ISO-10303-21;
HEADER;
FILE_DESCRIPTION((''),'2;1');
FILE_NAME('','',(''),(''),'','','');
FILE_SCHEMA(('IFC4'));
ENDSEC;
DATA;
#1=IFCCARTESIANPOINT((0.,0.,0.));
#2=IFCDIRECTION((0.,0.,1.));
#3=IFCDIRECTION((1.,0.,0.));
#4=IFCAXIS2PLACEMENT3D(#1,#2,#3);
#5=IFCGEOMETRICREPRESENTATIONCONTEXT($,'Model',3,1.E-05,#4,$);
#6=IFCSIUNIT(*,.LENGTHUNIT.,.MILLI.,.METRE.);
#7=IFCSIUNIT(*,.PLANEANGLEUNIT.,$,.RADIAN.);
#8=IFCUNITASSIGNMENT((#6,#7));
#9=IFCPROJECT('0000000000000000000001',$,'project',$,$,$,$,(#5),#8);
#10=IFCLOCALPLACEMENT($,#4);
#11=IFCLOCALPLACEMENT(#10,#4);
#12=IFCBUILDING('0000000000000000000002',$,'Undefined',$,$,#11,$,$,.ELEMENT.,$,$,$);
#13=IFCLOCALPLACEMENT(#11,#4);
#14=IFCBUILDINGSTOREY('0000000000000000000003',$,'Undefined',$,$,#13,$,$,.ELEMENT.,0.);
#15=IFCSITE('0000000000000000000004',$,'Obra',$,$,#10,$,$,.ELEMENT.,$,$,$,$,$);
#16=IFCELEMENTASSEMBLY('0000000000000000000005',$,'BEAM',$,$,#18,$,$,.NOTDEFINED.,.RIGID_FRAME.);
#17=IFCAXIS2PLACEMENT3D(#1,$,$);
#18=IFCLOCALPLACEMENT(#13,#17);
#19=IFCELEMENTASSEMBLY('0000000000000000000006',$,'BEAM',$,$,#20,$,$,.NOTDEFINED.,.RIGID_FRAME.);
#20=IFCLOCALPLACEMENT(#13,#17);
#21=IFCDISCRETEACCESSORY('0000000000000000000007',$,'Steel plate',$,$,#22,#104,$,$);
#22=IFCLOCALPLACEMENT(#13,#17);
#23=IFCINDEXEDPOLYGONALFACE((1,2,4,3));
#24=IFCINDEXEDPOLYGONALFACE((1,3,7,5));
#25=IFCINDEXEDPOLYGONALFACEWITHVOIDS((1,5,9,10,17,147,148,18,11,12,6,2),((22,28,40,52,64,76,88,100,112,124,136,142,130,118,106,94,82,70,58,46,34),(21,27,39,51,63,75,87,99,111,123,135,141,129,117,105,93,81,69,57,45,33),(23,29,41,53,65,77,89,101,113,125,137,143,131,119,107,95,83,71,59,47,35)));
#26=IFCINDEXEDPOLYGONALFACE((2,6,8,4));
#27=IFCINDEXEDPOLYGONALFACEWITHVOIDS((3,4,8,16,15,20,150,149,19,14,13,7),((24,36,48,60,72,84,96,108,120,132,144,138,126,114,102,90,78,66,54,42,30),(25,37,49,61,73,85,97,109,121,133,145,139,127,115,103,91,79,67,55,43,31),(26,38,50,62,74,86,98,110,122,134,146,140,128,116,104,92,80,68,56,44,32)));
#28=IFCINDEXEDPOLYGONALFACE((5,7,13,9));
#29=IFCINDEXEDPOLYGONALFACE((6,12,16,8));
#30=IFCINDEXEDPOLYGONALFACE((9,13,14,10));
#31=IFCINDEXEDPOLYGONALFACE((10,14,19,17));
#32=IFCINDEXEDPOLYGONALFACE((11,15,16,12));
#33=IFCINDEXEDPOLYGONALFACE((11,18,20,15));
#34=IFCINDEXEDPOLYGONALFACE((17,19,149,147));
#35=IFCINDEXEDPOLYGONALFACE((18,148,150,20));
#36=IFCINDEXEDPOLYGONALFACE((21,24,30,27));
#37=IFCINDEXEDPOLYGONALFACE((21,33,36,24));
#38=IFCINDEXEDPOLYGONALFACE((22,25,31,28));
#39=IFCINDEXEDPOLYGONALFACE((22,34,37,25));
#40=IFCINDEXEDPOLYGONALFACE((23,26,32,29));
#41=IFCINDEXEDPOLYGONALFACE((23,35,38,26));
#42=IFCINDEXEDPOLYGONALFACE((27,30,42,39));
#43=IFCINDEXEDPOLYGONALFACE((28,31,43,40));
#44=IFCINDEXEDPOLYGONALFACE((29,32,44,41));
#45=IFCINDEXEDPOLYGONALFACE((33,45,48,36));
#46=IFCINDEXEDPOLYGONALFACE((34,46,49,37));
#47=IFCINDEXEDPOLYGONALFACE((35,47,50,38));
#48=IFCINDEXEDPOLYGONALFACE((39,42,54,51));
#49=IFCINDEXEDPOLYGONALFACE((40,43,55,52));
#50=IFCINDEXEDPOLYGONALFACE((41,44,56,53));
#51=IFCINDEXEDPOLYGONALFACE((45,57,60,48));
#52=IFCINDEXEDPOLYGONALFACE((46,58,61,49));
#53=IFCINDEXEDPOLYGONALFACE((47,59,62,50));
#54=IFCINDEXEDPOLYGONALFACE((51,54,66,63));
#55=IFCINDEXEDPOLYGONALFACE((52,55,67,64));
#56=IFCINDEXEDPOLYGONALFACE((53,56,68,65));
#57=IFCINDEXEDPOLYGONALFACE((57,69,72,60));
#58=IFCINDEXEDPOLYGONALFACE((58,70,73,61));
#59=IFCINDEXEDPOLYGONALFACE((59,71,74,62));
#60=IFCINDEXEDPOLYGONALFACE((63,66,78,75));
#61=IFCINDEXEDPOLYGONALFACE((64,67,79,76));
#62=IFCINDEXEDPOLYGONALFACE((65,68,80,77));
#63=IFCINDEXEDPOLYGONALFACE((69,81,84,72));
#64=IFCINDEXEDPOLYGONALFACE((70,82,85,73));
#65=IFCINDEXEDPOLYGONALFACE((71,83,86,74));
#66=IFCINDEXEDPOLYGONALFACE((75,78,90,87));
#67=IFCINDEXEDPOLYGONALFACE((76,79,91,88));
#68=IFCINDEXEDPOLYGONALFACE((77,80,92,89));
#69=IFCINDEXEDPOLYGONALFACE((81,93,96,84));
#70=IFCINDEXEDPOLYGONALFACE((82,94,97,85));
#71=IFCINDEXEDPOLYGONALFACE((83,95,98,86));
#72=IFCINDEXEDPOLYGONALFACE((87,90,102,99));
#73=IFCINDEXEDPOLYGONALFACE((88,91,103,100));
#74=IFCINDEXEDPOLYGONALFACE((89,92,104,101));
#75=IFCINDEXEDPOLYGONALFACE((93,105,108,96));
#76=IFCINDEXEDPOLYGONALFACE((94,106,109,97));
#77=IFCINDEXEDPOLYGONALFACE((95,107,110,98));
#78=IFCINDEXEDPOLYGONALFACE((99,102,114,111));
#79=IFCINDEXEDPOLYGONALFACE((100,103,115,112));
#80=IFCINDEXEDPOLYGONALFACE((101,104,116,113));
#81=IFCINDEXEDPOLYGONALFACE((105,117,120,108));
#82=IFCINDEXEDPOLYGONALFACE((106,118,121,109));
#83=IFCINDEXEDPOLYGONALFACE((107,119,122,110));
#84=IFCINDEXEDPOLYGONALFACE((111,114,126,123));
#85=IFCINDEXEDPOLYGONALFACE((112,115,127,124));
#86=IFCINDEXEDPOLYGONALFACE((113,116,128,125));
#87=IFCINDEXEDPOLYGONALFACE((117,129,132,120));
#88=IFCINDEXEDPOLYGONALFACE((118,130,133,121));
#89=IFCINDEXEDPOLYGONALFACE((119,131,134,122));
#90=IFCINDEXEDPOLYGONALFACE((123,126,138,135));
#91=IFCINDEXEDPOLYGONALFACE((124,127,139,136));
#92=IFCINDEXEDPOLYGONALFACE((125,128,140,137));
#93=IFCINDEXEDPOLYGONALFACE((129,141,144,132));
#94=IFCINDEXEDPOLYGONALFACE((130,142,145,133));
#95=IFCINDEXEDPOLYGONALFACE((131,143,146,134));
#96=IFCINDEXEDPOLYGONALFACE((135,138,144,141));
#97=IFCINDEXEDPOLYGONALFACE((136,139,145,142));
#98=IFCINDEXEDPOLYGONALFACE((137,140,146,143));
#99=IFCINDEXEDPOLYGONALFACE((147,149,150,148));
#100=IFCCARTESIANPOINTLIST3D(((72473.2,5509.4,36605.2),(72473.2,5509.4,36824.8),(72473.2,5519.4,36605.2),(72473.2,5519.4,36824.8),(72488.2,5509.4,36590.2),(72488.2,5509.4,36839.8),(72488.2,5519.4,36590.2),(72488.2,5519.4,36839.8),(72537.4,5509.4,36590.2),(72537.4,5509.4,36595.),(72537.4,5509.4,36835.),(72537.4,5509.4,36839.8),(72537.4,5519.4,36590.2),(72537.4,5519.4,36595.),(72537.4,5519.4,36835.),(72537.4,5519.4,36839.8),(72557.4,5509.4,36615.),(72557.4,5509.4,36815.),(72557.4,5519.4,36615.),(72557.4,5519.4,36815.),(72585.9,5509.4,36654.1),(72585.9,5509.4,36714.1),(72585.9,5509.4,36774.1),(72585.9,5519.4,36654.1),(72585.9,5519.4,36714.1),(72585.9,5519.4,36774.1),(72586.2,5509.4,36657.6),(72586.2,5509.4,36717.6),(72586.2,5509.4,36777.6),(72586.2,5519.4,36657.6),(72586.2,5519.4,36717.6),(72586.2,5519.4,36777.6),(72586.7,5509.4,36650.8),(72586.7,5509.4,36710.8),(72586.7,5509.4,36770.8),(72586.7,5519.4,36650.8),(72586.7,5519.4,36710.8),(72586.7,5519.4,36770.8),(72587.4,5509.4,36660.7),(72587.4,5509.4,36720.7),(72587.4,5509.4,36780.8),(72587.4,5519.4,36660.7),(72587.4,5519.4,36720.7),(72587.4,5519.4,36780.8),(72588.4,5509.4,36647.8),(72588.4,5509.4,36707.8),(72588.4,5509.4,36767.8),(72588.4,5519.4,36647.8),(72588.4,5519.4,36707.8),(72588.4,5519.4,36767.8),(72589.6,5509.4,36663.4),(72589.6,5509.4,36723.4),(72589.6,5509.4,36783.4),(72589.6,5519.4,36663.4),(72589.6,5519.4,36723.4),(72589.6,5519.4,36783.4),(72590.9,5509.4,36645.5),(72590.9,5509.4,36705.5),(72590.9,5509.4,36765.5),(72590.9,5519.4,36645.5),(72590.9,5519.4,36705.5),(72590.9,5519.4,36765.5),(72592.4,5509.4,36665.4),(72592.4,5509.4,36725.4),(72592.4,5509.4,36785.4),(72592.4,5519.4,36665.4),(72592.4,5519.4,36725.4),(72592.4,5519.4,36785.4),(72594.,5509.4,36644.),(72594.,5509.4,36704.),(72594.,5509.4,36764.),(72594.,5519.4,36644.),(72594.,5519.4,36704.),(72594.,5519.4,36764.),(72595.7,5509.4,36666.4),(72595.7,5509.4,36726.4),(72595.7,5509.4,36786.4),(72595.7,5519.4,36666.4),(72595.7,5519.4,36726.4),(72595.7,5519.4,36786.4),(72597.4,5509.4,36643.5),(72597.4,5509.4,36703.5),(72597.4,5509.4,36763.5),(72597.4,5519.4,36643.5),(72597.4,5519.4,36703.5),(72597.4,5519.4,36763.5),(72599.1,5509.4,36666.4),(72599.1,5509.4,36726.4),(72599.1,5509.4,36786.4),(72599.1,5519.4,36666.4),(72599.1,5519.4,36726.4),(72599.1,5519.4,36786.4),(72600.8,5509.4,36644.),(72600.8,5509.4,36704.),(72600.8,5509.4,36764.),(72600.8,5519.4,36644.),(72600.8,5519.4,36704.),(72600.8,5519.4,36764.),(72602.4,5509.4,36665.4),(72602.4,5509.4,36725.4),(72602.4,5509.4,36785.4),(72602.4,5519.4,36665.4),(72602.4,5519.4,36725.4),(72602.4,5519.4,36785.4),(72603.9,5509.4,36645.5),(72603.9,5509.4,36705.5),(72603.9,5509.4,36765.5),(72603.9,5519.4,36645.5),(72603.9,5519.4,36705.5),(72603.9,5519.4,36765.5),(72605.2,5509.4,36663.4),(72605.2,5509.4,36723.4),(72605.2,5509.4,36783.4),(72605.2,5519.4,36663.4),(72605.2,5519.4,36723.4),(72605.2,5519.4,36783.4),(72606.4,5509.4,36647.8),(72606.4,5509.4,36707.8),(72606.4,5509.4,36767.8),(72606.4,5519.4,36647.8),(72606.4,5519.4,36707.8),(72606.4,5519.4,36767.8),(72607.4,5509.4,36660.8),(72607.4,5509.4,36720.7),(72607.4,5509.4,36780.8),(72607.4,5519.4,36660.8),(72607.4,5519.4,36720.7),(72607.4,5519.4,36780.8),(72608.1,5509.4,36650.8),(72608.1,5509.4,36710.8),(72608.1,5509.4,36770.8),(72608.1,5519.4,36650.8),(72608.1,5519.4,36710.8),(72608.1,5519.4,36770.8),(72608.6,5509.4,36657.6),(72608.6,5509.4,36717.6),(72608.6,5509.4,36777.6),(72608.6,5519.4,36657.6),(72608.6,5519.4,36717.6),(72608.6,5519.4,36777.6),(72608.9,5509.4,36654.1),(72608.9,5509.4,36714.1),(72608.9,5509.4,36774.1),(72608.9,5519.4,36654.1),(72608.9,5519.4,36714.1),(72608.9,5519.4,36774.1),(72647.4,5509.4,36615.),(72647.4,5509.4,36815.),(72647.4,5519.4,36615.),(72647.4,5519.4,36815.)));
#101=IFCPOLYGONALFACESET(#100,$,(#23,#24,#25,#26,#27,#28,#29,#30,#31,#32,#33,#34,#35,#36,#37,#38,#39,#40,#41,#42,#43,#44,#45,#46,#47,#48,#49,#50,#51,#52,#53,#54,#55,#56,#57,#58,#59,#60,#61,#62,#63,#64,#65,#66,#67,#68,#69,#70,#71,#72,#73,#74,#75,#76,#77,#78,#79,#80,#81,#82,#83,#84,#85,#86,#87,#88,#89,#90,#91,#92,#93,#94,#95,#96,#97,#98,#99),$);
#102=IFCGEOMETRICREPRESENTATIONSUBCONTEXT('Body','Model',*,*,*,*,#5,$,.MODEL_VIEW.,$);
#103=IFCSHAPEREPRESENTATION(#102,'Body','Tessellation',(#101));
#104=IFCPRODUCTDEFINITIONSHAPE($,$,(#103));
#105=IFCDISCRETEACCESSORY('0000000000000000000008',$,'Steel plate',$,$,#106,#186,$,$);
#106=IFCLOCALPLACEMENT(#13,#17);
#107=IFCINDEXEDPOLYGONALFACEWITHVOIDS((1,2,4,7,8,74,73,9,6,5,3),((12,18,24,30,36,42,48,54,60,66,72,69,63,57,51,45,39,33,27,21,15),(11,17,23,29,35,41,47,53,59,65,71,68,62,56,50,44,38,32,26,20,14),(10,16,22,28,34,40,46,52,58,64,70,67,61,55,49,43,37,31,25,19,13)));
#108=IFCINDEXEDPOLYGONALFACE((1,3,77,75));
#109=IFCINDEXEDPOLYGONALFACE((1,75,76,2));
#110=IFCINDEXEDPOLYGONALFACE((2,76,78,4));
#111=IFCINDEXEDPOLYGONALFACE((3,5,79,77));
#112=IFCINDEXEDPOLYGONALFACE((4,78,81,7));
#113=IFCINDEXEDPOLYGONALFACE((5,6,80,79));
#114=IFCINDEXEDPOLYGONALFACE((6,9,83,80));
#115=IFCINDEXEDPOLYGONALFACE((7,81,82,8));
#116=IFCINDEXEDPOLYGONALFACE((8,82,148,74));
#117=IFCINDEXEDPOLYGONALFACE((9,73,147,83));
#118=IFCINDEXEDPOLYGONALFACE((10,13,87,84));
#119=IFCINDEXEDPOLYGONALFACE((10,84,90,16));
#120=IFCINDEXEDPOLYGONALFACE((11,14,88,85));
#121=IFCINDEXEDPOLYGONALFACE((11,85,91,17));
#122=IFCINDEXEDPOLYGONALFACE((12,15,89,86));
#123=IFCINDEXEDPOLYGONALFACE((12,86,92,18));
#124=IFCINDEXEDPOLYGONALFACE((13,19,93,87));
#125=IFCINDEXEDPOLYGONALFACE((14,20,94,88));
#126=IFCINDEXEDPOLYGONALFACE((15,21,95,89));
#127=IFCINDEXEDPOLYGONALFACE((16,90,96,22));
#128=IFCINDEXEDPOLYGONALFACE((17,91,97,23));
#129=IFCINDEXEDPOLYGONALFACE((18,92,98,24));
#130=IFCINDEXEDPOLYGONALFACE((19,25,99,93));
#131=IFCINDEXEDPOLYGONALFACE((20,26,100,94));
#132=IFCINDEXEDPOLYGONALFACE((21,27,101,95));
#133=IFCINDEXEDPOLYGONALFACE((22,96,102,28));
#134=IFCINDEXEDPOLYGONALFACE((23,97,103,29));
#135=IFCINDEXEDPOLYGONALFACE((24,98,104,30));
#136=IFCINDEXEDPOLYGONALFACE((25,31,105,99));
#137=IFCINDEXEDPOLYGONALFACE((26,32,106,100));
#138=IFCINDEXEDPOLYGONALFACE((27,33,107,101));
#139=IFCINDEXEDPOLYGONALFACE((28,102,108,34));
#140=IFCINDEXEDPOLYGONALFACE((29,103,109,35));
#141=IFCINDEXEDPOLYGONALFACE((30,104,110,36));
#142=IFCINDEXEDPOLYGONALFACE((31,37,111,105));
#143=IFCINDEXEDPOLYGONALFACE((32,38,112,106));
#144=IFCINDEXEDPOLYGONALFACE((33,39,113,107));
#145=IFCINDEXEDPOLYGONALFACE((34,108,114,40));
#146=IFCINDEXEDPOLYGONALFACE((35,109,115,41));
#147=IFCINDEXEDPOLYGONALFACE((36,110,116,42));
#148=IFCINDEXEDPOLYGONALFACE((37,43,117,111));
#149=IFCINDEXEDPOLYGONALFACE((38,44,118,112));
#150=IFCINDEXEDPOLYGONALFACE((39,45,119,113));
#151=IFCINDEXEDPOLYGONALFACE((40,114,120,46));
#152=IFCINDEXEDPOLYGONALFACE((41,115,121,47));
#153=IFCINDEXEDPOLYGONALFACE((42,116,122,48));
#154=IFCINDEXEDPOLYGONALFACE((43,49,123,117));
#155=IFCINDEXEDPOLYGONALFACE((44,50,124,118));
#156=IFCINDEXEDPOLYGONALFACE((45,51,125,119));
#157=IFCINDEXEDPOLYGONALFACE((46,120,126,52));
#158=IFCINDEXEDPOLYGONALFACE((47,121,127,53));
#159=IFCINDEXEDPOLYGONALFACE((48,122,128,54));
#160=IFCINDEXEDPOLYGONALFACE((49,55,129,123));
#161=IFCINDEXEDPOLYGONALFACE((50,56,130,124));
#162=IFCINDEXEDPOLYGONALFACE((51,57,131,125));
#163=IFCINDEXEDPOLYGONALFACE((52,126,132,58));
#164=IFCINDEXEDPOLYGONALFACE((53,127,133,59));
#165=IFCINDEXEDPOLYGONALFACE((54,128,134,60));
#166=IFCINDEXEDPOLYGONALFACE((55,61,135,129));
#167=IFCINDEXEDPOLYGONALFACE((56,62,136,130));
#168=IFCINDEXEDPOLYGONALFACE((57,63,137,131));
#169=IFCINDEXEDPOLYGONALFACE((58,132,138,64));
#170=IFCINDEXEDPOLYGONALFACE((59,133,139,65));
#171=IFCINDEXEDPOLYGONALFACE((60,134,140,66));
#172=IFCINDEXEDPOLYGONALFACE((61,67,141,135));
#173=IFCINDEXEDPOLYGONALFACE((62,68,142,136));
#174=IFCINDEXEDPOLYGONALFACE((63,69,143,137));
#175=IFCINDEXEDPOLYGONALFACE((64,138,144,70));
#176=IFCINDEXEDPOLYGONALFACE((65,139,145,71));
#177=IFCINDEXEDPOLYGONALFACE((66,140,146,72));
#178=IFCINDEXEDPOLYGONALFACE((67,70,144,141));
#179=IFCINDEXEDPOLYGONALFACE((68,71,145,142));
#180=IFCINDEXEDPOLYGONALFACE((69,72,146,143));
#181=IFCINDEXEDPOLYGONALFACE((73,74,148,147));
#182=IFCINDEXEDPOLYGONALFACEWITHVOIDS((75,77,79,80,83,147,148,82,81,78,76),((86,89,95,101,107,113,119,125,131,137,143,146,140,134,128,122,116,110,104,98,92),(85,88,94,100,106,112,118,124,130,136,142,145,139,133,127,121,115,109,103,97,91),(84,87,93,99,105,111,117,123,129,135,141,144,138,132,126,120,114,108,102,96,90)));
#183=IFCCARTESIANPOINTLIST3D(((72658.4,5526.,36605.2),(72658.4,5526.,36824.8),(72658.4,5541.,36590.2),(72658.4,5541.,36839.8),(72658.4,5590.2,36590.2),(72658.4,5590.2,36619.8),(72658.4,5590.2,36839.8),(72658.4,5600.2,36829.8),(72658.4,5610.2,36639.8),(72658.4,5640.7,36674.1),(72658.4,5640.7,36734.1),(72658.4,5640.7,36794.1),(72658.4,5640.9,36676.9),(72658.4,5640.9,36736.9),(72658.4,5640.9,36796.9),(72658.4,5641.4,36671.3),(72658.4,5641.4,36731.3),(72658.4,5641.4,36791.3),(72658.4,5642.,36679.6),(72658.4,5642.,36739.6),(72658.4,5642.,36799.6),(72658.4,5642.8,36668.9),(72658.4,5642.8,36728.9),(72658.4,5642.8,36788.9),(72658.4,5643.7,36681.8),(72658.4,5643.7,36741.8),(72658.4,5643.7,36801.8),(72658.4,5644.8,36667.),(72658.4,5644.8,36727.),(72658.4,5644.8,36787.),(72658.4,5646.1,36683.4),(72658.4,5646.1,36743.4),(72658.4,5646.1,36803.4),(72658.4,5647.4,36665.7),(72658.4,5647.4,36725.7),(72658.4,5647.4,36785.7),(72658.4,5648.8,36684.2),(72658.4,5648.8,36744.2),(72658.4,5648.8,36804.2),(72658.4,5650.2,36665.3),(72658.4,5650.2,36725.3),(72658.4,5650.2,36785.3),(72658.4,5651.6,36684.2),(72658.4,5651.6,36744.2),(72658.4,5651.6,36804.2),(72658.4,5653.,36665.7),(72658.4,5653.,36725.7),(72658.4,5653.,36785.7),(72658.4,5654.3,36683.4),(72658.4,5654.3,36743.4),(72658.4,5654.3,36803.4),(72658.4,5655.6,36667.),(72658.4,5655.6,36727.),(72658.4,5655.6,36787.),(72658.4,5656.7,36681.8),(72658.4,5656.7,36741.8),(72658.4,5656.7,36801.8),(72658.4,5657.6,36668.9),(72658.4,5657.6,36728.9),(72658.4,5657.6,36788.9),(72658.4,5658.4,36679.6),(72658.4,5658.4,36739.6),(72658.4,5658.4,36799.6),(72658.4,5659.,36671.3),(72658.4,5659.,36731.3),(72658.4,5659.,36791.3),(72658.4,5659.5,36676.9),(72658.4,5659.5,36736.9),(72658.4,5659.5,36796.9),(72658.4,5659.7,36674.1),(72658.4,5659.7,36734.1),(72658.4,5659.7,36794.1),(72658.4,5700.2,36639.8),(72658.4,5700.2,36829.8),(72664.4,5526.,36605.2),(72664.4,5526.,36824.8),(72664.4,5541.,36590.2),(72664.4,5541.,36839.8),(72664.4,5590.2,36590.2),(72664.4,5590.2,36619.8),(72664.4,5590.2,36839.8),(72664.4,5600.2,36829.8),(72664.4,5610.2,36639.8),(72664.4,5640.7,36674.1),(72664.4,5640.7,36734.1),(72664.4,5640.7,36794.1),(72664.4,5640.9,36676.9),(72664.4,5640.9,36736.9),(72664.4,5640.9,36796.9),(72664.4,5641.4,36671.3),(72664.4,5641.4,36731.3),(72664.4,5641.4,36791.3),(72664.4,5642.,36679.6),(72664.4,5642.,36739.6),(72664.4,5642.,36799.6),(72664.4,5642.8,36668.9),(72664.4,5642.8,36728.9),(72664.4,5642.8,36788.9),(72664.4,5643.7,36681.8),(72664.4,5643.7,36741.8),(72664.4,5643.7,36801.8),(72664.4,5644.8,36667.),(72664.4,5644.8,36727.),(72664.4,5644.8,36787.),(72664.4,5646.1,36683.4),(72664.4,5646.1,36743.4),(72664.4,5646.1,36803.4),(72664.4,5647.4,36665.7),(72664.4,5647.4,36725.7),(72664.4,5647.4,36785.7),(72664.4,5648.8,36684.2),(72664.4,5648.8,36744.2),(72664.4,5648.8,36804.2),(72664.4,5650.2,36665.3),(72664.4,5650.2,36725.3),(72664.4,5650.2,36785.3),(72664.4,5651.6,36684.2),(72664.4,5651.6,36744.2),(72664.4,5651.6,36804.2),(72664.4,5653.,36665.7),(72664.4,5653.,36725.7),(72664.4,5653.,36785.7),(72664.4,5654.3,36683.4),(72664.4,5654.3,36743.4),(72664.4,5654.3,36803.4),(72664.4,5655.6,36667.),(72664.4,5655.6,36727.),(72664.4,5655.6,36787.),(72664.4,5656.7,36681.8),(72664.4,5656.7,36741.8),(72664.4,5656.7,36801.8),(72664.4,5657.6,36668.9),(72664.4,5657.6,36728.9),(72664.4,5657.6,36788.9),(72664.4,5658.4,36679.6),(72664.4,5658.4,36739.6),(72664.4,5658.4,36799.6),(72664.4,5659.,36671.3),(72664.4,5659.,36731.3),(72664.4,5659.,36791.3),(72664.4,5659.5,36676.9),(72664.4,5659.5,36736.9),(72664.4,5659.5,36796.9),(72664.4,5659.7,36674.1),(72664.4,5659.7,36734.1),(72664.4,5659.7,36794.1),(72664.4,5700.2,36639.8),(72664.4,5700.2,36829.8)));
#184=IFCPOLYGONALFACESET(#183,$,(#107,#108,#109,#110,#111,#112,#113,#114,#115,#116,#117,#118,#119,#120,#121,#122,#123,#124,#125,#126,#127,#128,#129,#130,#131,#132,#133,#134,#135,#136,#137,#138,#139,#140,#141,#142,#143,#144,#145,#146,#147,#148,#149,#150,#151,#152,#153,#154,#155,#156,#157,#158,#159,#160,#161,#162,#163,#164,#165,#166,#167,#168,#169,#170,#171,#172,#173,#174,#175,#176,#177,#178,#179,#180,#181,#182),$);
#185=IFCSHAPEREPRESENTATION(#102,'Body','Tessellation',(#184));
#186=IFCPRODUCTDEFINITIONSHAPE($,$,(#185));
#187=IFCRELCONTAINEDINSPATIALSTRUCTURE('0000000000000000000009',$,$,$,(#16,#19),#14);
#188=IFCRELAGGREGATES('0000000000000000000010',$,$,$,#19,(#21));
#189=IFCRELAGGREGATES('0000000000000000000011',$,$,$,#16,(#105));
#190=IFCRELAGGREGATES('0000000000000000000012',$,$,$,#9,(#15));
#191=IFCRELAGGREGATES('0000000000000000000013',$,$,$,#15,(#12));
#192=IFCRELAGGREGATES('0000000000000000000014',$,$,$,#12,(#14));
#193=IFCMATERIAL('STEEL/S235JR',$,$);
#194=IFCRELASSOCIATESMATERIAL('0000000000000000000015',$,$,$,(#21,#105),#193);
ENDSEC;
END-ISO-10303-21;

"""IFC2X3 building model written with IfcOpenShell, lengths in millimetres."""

from ifc_helpers import new_model, si_unit, frame, origin_with_axes, origin_2d_with_axis, place, context, subcontext, project, spatial, polyline, circle, outline, extrude, source, transform, mapped, material, element, aggregate, save


model = new_model("IFC2X3")

# Units and contexts
model_context = context("Model", 3, precision=1e-05, world=origin_with_axes())
body_context = subcontext(model_context, "Body", "Model", "MODEL_VIEW")
ifc_project = project(units=[si_unit("LENGTHUNIT", "METRE", prefix="MILLI"), si_unit("PLANEANGLEUNIT", "RADIAN")], contexts=[model_context])

# Site, building, storey
site_placement = place(None, origin_with_axes())
site = spatial("IfcSite", under=ifc_project, at=site_placement, Name="Obra", CompositionType="ELEMENT")
building_placement = place(site_placement, origin_with_axes())
building = spatial("IfcBuilding", under=site, at=building_placement, Name="Undefined", CompositionType="ELEMENT")
storey_placement = place(building_placement, origin_with_axes())
storey = spatial("IfcBuildingStorey", under=building, at=storey_placement, Name="Undefined", CompositionType="ELEMENT", Elevation=0.0)

# Shared definitions
ifc_material_1 = material(Name="STEEL/S235JR")

# Element assembly
assembly_1_placement = place(storey_placement, origin_with_axes())
assembly_1 = element("IfcElementAssembly", 1, at=assembly_1_placement, inside=storey, Name="BEAM", AssemblyPlace="NOTDEFINED", PredefinedType="RIGID_FRAME")

# Element assembly, discrete accessory, opening
assembly_2_placement = place(storey_placement, origin_with_axes())
assembly_2 = element("IfcElementAssembly", 2, at=assembly_2_placement, inside=storey, Name="BEAM", AssemblyPlace="NOTDEFINED", PredefinedType="RIGID_FRAME")
discrete_accessory_1_placement = place(assembly_2_placement, frame((72473.2, 5514.4, 36605.2), z_axis=(0.000002, -1.0, 0.0), x_axis=(0.707107, 0.000001, -0.707107)))
discrete_accessory_1 = element("IfcDiscreteAccessory", 3, at=discrete_accessory_1_placement, material=ifc_material_1, Name="Steel plate", context=body_context, shape_type="SweptSolid", body=[
    extrude(outline(polyline([(0.0, 0.0), (21.2, 0.0), (56.0, 34.8), (52.6, 38.2), (52.6, 66.5), (116.2, 130.1), (-25.2, 271.5), (-88.8, 207.9), (-117.1, 207.9), (-120.5, 211.3), (-155.3, 176.5), (-155.3, 155.3), (0.0, 0.0)])), frame((0.0, 0.0, -5.0), z_axis=(0.0, 0.0, 1.0), x_axis=(1.0, 0.0, 0.0)), (0.0, 0.0, 1.0), 10.0),
])
shared_shape_1 = source(origin_with_axes(), body_context, "Body", "SweptSolid", [
    extrude(circle(Radius=11.5, at=origin_2d_with_axis()), frame((0.0, -13.4, 0.0), z_axis=(0.0, 1.0, 0.0), x_axis=(1.0, 0.0, 0.0)), (0.0, 0.0, 1.0), 10.2),
])
opening_1_placement = place(assembly_2_placement, frame((72547.4, 5522.7, 36815.0), z_axis=(1.0, 0.000002, 0.0), x_axis=(0.0, 0.0, -1.0)))
element("IfcOpeningElement", 4, at=opening_1_placement, cuts=discrete_accessory_1, ObjectType="Opening", context=body_context, shape_type="MappedRepresentation", body=[
    mapped(shared_shape_1, transform((40.0, 0.0, 50.0))),
    mapped(shared_shape_1, transform((100.0, 0.0, 50.0))),
    mapped(shared_shape_1, transform((160.0, 0.0, 50.0))),
])
aggregate(assembly_2, [discrete_accessory_1])

# Discrete accessory, opening
discrete_accessory_2_placement = place(assembly_1_placement, frame((72661.4, 5526.0, 36605.2), z_axis=(1.0, 0.0, 0.0), x_axis=(0.0, 0.707107, -0.707107)))
discrete_accessory_2 = element("IfcDiscreteAccessory", 5, at=discrete_accessory_2_placement, material=ifc_material_1, Name="Steel plate", context=body_context, shape_type="SweptSolid", body=[
    extrude(outline(polyline([(0.0, 0.0), (21.2, 0.0), (56.0, 34.8), (35.1, 55.7), (35.1, 84.0), (98.7, 147.6), (-35.6, 282.0), (-106.3, 211.3), (-120.5, 211.3), (-120.5, 211.3), (-155.3, 176.5), (-155.3, 155.3), (0.0, 0.0)])), frame((0.0, 0.0, -3.0), z_axis=(0.0, 0.0, 1.0), x_axis=(1.0, 0.0, 0.0)), (0.0, 0.0, 1.0), 6.0),
])
shared_shape_2 = source(origin_with_axes(), body_context, "Body", "SweptSolid", [
    extrude(circle(Radius=9.5, at=origin_2d_with_axis()), frame((0.0, 3.0, 0.0), z_axis=(0.0, 1.0, 0.0), x_axis=(1.0, 0.0, 0.0)), (0.0, 0.0, 1.0), 6.2),
])
opening_2_placement = place(assembly_1_placement, frame((72667.5, 5600.2, 36829.8), z_axis=(0.0, 1.0, 0.0), x_axis=(0.0, 0.0, -1.0)))
element("IfcOpeningElement", 6, at=opening_2_placement, cuts=discrete_accessory_2, ObjectType="Opening", context=body_context, shape_type="MappedRepresentation", body=[
    mapped(shared_shape_2, transform((35.0, 0.0, 50.0))),
    mapped(shared_shape_2, transform((95.0, 0.0, 50.0))),
    mapped(shared_shape_2, transform((155.0, 0.0, 50.0))),
])
aggregate(assembly_1, [discrete_accessory_2])

save(model, "model.ifc")
